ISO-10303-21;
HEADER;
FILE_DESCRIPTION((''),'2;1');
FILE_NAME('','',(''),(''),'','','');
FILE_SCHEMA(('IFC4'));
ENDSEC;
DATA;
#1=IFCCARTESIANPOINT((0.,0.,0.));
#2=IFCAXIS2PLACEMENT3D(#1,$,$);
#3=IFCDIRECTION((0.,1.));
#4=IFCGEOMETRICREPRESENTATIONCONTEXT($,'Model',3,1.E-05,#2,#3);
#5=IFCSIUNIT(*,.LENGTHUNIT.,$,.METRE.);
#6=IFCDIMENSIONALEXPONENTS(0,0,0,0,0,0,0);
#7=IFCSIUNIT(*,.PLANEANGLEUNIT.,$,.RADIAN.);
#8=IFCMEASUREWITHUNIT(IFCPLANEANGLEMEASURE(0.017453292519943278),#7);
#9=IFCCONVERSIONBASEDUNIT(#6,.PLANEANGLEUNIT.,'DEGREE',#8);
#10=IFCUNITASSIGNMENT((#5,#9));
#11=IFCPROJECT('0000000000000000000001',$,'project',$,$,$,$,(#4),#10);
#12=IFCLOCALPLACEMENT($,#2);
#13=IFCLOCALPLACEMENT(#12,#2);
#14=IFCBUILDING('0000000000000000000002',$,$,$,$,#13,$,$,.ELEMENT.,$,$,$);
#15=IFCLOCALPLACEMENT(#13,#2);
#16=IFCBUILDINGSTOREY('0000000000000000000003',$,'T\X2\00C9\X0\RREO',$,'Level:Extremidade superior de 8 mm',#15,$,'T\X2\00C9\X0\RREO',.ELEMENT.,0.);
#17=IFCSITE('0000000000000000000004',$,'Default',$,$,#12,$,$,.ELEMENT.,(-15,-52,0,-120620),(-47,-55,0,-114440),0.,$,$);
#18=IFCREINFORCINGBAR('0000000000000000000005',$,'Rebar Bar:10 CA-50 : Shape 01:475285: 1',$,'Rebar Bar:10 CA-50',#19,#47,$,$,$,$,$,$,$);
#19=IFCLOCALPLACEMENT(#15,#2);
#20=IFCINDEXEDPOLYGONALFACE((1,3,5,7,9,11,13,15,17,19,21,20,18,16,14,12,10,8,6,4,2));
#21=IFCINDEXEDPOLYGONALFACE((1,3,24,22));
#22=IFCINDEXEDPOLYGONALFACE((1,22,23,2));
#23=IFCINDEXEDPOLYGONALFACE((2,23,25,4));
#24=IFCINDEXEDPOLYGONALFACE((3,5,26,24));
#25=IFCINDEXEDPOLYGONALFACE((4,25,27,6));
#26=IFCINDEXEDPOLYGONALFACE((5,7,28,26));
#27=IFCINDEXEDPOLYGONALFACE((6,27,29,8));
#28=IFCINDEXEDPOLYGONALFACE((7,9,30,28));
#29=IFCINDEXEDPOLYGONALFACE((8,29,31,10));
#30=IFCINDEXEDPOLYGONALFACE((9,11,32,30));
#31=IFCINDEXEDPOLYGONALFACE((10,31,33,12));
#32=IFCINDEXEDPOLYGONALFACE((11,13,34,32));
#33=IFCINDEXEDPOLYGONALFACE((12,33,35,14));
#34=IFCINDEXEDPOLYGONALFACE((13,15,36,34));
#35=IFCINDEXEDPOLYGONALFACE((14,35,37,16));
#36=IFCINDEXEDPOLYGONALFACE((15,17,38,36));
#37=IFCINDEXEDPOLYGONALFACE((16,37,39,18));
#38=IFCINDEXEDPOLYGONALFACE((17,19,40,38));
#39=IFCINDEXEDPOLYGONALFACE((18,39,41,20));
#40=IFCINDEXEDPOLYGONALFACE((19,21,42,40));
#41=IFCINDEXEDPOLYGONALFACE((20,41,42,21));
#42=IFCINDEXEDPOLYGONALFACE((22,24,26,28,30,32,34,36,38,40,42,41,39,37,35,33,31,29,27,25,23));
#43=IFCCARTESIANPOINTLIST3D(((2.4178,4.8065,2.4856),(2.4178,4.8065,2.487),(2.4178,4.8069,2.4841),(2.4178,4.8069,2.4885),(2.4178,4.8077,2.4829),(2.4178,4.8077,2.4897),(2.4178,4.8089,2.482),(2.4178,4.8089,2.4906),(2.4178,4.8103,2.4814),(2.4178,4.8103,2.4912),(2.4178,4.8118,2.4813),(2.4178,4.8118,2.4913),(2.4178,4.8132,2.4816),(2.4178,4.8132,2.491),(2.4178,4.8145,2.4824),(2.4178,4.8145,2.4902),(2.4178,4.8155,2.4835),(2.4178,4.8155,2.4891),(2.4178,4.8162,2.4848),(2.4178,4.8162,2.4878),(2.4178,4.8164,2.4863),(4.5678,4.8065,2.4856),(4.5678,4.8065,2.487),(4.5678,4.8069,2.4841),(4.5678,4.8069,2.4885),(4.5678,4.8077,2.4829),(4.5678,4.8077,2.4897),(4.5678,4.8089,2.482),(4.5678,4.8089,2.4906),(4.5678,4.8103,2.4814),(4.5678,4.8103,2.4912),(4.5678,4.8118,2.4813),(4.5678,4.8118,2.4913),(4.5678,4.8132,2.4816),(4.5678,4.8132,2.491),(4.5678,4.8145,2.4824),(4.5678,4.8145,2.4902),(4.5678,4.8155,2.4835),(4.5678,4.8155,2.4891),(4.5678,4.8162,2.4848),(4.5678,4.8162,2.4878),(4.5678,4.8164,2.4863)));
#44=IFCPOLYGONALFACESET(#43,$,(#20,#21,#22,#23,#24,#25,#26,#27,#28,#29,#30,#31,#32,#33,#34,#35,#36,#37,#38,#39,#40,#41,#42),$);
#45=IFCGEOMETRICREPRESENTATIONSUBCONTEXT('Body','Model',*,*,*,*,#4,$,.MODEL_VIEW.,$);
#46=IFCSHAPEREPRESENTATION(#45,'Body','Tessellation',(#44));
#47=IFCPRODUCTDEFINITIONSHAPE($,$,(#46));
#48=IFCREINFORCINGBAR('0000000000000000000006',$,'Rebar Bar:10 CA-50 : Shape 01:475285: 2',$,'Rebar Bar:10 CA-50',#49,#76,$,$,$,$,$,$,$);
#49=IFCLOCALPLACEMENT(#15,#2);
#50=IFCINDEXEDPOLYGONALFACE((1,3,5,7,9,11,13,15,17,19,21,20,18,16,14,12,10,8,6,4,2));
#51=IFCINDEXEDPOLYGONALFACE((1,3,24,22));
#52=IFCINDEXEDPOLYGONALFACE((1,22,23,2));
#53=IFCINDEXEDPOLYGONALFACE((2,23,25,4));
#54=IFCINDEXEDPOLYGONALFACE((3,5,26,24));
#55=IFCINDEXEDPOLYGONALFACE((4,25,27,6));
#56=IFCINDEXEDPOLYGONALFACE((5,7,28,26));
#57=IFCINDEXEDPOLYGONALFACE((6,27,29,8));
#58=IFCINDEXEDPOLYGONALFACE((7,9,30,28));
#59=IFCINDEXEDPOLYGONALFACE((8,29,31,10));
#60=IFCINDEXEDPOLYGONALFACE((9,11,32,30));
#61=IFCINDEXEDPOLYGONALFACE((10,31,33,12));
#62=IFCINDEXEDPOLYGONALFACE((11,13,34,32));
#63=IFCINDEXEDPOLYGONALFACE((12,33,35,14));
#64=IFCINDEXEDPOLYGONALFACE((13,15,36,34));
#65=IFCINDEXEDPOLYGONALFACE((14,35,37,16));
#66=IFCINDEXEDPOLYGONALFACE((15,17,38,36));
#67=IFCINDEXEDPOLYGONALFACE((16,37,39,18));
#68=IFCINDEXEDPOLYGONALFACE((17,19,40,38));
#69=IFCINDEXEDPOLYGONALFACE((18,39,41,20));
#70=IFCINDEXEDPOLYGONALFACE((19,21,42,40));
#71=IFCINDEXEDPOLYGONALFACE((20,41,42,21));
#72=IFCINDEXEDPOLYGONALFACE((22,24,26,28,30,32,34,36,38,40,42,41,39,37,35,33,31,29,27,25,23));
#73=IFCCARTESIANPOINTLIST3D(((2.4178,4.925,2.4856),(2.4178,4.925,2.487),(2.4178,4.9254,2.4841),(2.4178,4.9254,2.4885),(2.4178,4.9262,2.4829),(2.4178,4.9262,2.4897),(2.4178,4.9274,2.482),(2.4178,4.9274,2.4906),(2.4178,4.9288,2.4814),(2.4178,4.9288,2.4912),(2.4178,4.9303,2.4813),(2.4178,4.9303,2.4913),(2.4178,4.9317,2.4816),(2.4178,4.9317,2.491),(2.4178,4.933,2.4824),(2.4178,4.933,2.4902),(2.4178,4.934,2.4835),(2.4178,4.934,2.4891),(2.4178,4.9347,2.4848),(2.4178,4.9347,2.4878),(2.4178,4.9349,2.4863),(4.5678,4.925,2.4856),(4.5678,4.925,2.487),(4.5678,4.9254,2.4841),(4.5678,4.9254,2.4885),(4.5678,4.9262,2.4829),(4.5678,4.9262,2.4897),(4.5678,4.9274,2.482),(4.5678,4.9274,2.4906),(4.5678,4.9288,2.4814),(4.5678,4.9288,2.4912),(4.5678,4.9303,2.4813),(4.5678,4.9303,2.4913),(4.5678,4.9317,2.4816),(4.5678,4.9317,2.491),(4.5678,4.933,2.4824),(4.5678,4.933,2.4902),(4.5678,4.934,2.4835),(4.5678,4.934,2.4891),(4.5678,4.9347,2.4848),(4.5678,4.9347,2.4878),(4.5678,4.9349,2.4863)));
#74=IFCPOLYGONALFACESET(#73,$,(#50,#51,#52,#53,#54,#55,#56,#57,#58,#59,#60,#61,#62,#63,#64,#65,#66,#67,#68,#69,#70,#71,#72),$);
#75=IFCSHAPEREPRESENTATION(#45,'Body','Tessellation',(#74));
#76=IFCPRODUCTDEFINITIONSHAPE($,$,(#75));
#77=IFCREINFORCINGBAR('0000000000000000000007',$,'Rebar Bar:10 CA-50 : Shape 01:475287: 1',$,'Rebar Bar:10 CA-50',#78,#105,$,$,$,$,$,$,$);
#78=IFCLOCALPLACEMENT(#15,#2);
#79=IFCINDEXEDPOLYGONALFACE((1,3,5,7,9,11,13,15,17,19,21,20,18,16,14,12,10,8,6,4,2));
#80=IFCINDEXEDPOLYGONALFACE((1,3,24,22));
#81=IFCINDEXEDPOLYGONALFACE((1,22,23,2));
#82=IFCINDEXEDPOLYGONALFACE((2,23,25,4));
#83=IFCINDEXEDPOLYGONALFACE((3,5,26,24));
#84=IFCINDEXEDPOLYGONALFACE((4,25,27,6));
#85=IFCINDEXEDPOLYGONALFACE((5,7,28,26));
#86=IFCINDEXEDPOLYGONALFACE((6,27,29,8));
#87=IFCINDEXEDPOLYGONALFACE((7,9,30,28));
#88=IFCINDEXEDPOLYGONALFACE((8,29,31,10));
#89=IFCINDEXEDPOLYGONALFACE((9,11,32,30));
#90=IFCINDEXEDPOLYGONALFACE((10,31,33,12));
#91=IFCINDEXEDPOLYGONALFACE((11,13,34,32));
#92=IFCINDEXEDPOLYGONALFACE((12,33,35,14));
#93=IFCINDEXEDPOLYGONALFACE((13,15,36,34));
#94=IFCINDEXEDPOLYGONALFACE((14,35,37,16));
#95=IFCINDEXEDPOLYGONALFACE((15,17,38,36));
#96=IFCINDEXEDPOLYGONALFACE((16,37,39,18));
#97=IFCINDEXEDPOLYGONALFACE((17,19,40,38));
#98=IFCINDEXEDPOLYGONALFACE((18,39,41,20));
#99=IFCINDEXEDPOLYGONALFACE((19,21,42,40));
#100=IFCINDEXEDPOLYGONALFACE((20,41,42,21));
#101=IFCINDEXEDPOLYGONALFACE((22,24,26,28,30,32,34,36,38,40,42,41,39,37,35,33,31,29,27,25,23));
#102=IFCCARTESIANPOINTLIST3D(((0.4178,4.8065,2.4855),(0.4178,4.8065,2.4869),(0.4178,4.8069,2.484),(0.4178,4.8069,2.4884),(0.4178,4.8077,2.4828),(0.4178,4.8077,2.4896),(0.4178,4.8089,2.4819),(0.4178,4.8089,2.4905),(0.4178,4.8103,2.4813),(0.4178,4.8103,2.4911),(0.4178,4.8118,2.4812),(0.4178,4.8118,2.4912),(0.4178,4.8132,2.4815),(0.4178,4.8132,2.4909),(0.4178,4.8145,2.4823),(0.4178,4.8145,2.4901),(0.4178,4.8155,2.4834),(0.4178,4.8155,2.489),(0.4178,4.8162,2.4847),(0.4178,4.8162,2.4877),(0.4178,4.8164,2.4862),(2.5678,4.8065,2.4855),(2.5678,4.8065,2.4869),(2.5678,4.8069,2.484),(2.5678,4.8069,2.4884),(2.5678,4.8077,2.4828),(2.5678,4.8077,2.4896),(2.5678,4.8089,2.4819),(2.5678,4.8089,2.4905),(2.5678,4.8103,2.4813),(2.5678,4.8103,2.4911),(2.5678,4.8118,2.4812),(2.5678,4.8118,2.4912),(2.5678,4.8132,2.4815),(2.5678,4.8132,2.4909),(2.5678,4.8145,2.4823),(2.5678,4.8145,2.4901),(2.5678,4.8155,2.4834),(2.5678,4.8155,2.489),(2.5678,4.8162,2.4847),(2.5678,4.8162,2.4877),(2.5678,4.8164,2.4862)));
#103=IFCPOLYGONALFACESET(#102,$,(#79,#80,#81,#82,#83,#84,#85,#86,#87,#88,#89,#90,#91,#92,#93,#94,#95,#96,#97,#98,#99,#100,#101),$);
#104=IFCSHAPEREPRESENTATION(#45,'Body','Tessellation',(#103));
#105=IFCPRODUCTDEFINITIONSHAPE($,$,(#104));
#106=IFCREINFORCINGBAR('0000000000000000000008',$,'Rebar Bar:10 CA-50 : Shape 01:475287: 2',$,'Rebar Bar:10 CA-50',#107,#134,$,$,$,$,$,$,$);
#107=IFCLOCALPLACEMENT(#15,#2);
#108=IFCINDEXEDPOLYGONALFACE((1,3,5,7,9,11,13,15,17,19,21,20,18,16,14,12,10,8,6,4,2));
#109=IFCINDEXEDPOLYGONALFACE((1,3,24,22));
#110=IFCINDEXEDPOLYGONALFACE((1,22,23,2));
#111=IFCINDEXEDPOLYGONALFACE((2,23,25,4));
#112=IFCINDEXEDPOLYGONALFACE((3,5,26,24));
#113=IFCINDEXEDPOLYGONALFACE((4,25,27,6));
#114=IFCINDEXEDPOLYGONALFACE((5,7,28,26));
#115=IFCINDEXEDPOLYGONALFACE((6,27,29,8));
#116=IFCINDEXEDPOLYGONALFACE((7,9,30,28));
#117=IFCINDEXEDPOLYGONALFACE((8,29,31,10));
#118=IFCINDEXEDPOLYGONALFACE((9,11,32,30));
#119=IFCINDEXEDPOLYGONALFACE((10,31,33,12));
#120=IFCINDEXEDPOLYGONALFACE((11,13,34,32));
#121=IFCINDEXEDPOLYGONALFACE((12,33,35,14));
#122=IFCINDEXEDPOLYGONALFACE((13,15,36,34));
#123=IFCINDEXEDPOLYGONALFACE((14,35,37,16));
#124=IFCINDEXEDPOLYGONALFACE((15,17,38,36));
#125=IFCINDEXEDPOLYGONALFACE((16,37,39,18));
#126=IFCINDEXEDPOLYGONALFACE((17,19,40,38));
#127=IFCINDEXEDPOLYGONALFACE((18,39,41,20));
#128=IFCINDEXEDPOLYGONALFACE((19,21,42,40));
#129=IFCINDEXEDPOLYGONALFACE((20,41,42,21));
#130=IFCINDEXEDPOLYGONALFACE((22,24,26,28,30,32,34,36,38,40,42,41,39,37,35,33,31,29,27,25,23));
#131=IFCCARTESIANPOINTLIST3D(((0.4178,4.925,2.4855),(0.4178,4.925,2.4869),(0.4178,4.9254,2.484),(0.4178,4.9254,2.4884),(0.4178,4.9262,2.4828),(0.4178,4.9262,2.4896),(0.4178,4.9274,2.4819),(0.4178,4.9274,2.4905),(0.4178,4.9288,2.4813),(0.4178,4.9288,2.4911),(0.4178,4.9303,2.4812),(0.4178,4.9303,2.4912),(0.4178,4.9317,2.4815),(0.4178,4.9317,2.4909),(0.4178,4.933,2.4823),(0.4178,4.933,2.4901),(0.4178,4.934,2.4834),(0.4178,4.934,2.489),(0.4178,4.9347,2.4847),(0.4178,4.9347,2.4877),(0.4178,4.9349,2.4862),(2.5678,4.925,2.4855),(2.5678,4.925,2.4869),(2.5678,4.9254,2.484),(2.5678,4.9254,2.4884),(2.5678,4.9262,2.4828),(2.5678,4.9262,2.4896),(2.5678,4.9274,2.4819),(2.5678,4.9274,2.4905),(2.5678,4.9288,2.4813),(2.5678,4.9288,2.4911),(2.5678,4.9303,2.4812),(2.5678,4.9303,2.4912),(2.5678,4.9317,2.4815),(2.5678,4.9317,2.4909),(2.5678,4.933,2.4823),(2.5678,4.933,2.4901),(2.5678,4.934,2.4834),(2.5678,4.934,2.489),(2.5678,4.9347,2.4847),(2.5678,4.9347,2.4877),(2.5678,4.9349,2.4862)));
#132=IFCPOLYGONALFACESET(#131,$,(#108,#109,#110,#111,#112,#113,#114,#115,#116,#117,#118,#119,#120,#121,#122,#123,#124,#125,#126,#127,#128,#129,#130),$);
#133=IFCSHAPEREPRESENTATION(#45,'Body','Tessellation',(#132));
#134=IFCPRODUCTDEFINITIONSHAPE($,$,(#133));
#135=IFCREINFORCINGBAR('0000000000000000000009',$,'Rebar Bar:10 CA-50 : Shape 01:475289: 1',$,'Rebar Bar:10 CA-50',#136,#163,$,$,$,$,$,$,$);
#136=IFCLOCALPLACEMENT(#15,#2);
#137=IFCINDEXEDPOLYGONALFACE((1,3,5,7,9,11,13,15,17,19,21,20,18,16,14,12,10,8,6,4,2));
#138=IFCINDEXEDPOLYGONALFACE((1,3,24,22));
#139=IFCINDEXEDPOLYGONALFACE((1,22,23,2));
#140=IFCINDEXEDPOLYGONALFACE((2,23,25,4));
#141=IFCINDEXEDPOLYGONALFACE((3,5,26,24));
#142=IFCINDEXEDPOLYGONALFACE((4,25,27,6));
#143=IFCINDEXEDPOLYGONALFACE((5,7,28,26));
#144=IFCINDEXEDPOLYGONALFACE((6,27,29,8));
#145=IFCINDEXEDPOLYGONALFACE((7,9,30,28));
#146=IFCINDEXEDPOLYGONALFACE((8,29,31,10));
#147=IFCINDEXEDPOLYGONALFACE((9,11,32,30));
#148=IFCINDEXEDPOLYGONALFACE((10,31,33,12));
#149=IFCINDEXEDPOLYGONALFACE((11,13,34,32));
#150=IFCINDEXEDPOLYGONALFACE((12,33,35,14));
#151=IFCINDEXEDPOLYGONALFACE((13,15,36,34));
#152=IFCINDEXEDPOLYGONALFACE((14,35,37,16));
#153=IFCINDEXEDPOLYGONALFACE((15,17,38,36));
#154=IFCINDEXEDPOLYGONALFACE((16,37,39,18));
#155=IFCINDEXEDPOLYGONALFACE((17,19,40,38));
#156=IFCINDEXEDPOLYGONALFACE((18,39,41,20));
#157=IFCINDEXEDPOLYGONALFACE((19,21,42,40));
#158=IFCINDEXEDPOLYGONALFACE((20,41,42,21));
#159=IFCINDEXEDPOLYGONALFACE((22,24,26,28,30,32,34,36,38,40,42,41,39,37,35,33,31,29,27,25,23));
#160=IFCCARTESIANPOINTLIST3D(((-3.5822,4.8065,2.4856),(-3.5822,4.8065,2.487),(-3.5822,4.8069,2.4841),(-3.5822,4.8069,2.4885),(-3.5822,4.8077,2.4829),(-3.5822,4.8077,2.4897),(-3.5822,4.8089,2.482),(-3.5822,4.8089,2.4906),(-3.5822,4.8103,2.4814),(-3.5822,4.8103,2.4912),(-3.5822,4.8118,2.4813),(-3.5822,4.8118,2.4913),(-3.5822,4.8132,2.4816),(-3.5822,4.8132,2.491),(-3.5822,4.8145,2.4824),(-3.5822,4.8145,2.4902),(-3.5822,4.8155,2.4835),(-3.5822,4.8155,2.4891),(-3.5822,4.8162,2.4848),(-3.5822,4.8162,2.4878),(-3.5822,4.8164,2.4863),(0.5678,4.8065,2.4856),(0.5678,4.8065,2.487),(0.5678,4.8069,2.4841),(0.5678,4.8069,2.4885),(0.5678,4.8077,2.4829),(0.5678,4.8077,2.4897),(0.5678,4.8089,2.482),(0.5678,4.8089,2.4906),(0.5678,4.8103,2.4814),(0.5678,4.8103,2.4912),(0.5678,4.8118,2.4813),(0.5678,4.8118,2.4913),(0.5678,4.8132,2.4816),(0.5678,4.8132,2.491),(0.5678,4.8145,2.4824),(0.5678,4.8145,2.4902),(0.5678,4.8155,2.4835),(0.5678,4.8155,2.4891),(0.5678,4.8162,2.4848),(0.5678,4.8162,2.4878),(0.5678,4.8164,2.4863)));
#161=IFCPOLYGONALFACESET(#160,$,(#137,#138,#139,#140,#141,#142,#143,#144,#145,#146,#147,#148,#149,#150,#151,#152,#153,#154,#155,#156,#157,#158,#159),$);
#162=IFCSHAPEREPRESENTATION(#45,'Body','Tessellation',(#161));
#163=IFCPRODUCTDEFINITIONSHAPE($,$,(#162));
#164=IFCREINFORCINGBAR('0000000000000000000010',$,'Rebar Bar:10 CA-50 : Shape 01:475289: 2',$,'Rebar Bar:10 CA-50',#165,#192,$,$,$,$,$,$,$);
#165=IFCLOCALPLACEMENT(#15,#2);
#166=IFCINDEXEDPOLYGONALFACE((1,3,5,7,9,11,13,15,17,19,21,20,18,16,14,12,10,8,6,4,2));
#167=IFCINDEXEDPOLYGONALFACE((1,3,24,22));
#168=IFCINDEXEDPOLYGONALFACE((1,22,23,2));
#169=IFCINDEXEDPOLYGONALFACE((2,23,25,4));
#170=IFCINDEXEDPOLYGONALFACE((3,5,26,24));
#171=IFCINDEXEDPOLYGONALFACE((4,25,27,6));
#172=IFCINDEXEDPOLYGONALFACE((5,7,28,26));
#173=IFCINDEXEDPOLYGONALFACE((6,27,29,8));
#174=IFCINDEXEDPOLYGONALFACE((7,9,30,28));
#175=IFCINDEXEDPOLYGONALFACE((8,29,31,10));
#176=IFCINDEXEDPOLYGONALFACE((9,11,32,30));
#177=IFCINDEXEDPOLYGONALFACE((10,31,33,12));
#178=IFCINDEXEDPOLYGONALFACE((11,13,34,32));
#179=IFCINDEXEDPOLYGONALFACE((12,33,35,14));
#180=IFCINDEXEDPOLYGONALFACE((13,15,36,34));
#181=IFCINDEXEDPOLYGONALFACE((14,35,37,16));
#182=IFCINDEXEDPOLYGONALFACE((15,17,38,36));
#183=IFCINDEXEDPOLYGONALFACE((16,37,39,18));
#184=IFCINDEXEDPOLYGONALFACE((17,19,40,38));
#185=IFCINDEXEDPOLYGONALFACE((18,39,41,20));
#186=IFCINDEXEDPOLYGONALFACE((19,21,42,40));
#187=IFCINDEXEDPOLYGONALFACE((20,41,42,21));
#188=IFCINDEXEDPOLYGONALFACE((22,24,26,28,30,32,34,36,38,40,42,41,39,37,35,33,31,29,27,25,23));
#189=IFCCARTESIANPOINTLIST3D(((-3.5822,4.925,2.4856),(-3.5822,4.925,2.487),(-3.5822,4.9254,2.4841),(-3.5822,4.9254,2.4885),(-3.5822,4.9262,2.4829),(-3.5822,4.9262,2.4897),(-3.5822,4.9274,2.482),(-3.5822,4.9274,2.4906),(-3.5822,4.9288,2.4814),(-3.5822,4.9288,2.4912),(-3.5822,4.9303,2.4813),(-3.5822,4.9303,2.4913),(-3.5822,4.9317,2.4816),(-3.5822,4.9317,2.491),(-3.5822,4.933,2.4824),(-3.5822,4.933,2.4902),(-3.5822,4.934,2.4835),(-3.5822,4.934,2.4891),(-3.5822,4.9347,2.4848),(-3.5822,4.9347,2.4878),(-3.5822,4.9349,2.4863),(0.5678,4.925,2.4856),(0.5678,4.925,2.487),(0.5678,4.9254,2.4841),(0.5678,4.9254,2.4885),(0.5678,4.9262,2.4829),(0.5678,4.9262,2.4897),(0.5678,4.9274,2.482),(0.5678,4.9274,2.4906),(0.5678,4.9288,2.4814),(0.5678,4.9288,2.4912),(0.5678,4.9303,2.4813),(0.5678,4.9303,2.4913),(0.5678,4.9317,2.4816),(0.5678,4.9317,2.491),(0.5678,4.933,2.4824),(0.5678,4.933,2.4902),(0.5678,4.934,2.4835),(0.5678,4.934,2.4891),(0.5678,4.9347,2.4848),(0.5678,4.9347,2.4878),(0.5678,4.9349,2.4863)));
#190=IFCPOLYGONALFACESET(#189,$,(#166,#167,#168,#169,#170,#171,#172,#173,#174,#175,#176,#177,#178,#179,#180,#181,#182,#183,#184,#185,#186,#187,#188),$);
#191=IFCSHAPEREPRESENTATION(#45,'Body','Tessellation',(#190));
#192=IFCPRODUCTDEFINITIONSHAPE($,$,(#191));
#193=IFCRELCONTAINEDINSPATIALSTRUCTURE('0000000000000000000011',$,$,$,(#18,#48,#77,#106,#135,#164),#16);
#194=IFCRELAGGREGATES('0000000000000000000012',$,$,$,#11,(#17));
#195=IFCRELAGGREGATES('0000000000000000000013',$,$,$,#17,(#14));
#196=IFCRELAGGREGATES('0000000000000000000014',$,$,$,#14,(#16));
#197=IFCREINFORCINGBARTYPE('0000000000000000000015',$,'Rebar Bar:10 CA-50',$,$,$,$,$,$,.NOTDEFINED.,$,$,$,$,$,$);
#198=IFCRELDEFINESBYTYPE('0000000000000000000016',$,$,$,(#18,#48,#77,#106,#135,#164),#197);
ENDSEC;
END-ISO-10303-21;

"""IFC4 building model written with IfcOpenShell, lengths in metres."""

from ifc_helpers import new_model, entity, si_unit, converted_unit, direction, origin, place, context, subcontext, project, spatial, type_object, element, save


model = new_model("IFC4")

# Units and contexts
model_context = context("Model", 3, precision=1e-05, world=origin(), true_north=direction((0.0, 1.0)))
body_context = subcontext(model_context, "Body", "Model", "MODEL_VIEW")
ifc_project = project(units=[si_unit("LENGTHUNIT", "METRE"), converted_unit("PLANEANGLEUNIT", "DEGREE", entity("IfcPlaneAngleMeasure", 0.017453292519943278), si_unit("PLANEANGLEUNIT", "RADIAN"), dimensions=[0, 0, 0, 0, 0, 0, 0])], contexts=[model_context])

# Site, building, storey
site_placement = place(None, origin())
site = spatial("IfcSite", under=ifc_project, at=site_placement, Name="Default", CompositionType="ELEMENT", RefLatitude=(-15, -52, 0, -120620), RefLongitude=(-47, -55, 0, -114440), RefElevation=0.0)
building_placement = place(site_placement, origin())
building = spatial("IfcBuilding", under=site, at=building_placement, CompositionType="ELEMENT")
storey_placement = place(building_placement, origin())
storey = spatial("IfcBuildingStorey", under=building, at=storey_placement, Name="TÉRREO", ObjectType="Level:Extremidade superior de 8 mm", LongName="TÉRREO", CompositionType="ELEMENT", Elevation=0.0)

# Reinforcing bars
reinforcing_bar_type_1 = type_object("IfcReinforcingBarType", Name="Rebar Bar:10 CA-50", PredefinedType="NOTDEFINED")
reinforcing_bar_1_placement = place(storey_placement, origin())
element("IfcReinforcingBar", 1, at=reinforcing_bar_1_placement, inside=storey, type_object=reinforcing_bar_type_1, Name="Rebar Bar:10 CA-50 : Shape 01:475285: 1", ObjectType="Rebar Bar:10 CA-50", context=body_context, shape_type="AdvancedSweptSolid", body=[
    entity("IfcSweptDiskSolid", entity("IfcIndexedPolyCurve", entity("IfcCartesianPointList3D", [[2.4178, 4.8114, 2.4863], [4.5678, 4.8114, 2.4863]]), None, False), 0.005, None, 0.0, 1.0),
])
reinforcing_bar_2_placement = place(storey_placement, origin())
element("IfcReinforcingBar", 2, at=reinforcing_bar_2_placement, inside=storey, type_object=reinforcing_bar_type_1, Name="Rebar Bar:10 CA-50 : Shape 01:475285: 2", ObjectType="Rebar Bar:10 CA-50", context=body_context, shape_type="AdvancedSweptSolid", body=[
    entity("IfcSweptDiskSolid", entity("IfcIndexedPolyCurve", entity("IfcCartesianPointList3D", [[2.4178, 4.9299, 2.4863], [4.5678, 4.9299, 2.4863]]), None, False), 0.005, None, 0.0, 1.0),
])
reinforcing_bar_3_placement = place(storey_placement, origin())
element("IfcReinforcingBar", 3, at=reinforcing_bar_3_placement, inside=storey, type_object=reinforcing_bar_type_1, Name="Rebar Bar:10 CA-50 : Shape 01:475287: 1", ObjectType="Rebar Bar:10 CA-50", context=body_context, shape_type="AdvancedSweptSolid", body=[
    entity("IfcSweptDiskSolid", entity("IfcIndexedPolyCurve", entity("IfcCartesianPointList3D", [[0.4178, 4.8114, 2.4862], [2.5678, 4.8114, 2.4862]]), None, False), 0.005, None, 0.0, 1.0),
])
reinforcing_bar_4_placement = place(storey_placement, origin())
element("IfcReinforcingBar", 4, at=reinforcing_bar_4_placement, inside=storey, type_object=reinforcing_bar_type_1, Name="Rebar Bar:10 CA-50 : Shape 01:475287: 2", ObjectType="Rebar Bar:10 CA-50", context=body_context, shape_type="AdvancedSweptSolid", body=[
    entity("IfcSweptDiskSolid", entity("IfcIndexedPolyCurve", entity("IfcCartesianPointList3D", [[0.4178, 4.9299, 2.4862], [2.5678, 4.9299, 2.4862]]), None, False), 0.005, None, 0.0, 1.0),
])
reinforcing_bar_5_placement = place(storey_placement, origin())
element("IfcReinforcingBar", 5, at=reinforcing_bar_5_placement, inside=storey, type_object=reinforcing_bar_type_1, Name="Rebar Bar:10 CA-50 : Shape 01:475289: 1", ObjectType="Rebar Bar:10 CA-50", context=body_context, shape_type="AdvancedSweptSolid", body=[
    entity("IfcSweptDiskSolid", entity("IfcIndexedPolyCurve", entity("IfcCartesianPointList3D", [[-3.5822, 4.8114, 2.4863], [0.5678, 4.8114, 2.4863]]), None, False), 0.005, None, 0.0, 1.0),
])
reinforcing_bar_6_placement = place(storey_placement, origin())
element("IfcReinforcingBar", 6, at=reinforcing_bar_6_placement, inside=storey, type_object=reinforcing_bar_type_1, Name="Rebar Bar:10 CA-50 : Shape 01:475289: 2", ObjectType="Rebar Bar:10 CA-50", context=body_context, shape_type="AdvancedSweptSolid", body=[
    entity("IfcSweptDiskSolid", entity("IfcIndexedPolyCurve", entity("IfcCartesianPointList3D", [[-3.5822, 4.9299, 2.4863], [0.5678, 4.9299, 2.4863]]), None, False), 0.005, None, 0.0, 1.0),
])

save(model, "model.ifc")
